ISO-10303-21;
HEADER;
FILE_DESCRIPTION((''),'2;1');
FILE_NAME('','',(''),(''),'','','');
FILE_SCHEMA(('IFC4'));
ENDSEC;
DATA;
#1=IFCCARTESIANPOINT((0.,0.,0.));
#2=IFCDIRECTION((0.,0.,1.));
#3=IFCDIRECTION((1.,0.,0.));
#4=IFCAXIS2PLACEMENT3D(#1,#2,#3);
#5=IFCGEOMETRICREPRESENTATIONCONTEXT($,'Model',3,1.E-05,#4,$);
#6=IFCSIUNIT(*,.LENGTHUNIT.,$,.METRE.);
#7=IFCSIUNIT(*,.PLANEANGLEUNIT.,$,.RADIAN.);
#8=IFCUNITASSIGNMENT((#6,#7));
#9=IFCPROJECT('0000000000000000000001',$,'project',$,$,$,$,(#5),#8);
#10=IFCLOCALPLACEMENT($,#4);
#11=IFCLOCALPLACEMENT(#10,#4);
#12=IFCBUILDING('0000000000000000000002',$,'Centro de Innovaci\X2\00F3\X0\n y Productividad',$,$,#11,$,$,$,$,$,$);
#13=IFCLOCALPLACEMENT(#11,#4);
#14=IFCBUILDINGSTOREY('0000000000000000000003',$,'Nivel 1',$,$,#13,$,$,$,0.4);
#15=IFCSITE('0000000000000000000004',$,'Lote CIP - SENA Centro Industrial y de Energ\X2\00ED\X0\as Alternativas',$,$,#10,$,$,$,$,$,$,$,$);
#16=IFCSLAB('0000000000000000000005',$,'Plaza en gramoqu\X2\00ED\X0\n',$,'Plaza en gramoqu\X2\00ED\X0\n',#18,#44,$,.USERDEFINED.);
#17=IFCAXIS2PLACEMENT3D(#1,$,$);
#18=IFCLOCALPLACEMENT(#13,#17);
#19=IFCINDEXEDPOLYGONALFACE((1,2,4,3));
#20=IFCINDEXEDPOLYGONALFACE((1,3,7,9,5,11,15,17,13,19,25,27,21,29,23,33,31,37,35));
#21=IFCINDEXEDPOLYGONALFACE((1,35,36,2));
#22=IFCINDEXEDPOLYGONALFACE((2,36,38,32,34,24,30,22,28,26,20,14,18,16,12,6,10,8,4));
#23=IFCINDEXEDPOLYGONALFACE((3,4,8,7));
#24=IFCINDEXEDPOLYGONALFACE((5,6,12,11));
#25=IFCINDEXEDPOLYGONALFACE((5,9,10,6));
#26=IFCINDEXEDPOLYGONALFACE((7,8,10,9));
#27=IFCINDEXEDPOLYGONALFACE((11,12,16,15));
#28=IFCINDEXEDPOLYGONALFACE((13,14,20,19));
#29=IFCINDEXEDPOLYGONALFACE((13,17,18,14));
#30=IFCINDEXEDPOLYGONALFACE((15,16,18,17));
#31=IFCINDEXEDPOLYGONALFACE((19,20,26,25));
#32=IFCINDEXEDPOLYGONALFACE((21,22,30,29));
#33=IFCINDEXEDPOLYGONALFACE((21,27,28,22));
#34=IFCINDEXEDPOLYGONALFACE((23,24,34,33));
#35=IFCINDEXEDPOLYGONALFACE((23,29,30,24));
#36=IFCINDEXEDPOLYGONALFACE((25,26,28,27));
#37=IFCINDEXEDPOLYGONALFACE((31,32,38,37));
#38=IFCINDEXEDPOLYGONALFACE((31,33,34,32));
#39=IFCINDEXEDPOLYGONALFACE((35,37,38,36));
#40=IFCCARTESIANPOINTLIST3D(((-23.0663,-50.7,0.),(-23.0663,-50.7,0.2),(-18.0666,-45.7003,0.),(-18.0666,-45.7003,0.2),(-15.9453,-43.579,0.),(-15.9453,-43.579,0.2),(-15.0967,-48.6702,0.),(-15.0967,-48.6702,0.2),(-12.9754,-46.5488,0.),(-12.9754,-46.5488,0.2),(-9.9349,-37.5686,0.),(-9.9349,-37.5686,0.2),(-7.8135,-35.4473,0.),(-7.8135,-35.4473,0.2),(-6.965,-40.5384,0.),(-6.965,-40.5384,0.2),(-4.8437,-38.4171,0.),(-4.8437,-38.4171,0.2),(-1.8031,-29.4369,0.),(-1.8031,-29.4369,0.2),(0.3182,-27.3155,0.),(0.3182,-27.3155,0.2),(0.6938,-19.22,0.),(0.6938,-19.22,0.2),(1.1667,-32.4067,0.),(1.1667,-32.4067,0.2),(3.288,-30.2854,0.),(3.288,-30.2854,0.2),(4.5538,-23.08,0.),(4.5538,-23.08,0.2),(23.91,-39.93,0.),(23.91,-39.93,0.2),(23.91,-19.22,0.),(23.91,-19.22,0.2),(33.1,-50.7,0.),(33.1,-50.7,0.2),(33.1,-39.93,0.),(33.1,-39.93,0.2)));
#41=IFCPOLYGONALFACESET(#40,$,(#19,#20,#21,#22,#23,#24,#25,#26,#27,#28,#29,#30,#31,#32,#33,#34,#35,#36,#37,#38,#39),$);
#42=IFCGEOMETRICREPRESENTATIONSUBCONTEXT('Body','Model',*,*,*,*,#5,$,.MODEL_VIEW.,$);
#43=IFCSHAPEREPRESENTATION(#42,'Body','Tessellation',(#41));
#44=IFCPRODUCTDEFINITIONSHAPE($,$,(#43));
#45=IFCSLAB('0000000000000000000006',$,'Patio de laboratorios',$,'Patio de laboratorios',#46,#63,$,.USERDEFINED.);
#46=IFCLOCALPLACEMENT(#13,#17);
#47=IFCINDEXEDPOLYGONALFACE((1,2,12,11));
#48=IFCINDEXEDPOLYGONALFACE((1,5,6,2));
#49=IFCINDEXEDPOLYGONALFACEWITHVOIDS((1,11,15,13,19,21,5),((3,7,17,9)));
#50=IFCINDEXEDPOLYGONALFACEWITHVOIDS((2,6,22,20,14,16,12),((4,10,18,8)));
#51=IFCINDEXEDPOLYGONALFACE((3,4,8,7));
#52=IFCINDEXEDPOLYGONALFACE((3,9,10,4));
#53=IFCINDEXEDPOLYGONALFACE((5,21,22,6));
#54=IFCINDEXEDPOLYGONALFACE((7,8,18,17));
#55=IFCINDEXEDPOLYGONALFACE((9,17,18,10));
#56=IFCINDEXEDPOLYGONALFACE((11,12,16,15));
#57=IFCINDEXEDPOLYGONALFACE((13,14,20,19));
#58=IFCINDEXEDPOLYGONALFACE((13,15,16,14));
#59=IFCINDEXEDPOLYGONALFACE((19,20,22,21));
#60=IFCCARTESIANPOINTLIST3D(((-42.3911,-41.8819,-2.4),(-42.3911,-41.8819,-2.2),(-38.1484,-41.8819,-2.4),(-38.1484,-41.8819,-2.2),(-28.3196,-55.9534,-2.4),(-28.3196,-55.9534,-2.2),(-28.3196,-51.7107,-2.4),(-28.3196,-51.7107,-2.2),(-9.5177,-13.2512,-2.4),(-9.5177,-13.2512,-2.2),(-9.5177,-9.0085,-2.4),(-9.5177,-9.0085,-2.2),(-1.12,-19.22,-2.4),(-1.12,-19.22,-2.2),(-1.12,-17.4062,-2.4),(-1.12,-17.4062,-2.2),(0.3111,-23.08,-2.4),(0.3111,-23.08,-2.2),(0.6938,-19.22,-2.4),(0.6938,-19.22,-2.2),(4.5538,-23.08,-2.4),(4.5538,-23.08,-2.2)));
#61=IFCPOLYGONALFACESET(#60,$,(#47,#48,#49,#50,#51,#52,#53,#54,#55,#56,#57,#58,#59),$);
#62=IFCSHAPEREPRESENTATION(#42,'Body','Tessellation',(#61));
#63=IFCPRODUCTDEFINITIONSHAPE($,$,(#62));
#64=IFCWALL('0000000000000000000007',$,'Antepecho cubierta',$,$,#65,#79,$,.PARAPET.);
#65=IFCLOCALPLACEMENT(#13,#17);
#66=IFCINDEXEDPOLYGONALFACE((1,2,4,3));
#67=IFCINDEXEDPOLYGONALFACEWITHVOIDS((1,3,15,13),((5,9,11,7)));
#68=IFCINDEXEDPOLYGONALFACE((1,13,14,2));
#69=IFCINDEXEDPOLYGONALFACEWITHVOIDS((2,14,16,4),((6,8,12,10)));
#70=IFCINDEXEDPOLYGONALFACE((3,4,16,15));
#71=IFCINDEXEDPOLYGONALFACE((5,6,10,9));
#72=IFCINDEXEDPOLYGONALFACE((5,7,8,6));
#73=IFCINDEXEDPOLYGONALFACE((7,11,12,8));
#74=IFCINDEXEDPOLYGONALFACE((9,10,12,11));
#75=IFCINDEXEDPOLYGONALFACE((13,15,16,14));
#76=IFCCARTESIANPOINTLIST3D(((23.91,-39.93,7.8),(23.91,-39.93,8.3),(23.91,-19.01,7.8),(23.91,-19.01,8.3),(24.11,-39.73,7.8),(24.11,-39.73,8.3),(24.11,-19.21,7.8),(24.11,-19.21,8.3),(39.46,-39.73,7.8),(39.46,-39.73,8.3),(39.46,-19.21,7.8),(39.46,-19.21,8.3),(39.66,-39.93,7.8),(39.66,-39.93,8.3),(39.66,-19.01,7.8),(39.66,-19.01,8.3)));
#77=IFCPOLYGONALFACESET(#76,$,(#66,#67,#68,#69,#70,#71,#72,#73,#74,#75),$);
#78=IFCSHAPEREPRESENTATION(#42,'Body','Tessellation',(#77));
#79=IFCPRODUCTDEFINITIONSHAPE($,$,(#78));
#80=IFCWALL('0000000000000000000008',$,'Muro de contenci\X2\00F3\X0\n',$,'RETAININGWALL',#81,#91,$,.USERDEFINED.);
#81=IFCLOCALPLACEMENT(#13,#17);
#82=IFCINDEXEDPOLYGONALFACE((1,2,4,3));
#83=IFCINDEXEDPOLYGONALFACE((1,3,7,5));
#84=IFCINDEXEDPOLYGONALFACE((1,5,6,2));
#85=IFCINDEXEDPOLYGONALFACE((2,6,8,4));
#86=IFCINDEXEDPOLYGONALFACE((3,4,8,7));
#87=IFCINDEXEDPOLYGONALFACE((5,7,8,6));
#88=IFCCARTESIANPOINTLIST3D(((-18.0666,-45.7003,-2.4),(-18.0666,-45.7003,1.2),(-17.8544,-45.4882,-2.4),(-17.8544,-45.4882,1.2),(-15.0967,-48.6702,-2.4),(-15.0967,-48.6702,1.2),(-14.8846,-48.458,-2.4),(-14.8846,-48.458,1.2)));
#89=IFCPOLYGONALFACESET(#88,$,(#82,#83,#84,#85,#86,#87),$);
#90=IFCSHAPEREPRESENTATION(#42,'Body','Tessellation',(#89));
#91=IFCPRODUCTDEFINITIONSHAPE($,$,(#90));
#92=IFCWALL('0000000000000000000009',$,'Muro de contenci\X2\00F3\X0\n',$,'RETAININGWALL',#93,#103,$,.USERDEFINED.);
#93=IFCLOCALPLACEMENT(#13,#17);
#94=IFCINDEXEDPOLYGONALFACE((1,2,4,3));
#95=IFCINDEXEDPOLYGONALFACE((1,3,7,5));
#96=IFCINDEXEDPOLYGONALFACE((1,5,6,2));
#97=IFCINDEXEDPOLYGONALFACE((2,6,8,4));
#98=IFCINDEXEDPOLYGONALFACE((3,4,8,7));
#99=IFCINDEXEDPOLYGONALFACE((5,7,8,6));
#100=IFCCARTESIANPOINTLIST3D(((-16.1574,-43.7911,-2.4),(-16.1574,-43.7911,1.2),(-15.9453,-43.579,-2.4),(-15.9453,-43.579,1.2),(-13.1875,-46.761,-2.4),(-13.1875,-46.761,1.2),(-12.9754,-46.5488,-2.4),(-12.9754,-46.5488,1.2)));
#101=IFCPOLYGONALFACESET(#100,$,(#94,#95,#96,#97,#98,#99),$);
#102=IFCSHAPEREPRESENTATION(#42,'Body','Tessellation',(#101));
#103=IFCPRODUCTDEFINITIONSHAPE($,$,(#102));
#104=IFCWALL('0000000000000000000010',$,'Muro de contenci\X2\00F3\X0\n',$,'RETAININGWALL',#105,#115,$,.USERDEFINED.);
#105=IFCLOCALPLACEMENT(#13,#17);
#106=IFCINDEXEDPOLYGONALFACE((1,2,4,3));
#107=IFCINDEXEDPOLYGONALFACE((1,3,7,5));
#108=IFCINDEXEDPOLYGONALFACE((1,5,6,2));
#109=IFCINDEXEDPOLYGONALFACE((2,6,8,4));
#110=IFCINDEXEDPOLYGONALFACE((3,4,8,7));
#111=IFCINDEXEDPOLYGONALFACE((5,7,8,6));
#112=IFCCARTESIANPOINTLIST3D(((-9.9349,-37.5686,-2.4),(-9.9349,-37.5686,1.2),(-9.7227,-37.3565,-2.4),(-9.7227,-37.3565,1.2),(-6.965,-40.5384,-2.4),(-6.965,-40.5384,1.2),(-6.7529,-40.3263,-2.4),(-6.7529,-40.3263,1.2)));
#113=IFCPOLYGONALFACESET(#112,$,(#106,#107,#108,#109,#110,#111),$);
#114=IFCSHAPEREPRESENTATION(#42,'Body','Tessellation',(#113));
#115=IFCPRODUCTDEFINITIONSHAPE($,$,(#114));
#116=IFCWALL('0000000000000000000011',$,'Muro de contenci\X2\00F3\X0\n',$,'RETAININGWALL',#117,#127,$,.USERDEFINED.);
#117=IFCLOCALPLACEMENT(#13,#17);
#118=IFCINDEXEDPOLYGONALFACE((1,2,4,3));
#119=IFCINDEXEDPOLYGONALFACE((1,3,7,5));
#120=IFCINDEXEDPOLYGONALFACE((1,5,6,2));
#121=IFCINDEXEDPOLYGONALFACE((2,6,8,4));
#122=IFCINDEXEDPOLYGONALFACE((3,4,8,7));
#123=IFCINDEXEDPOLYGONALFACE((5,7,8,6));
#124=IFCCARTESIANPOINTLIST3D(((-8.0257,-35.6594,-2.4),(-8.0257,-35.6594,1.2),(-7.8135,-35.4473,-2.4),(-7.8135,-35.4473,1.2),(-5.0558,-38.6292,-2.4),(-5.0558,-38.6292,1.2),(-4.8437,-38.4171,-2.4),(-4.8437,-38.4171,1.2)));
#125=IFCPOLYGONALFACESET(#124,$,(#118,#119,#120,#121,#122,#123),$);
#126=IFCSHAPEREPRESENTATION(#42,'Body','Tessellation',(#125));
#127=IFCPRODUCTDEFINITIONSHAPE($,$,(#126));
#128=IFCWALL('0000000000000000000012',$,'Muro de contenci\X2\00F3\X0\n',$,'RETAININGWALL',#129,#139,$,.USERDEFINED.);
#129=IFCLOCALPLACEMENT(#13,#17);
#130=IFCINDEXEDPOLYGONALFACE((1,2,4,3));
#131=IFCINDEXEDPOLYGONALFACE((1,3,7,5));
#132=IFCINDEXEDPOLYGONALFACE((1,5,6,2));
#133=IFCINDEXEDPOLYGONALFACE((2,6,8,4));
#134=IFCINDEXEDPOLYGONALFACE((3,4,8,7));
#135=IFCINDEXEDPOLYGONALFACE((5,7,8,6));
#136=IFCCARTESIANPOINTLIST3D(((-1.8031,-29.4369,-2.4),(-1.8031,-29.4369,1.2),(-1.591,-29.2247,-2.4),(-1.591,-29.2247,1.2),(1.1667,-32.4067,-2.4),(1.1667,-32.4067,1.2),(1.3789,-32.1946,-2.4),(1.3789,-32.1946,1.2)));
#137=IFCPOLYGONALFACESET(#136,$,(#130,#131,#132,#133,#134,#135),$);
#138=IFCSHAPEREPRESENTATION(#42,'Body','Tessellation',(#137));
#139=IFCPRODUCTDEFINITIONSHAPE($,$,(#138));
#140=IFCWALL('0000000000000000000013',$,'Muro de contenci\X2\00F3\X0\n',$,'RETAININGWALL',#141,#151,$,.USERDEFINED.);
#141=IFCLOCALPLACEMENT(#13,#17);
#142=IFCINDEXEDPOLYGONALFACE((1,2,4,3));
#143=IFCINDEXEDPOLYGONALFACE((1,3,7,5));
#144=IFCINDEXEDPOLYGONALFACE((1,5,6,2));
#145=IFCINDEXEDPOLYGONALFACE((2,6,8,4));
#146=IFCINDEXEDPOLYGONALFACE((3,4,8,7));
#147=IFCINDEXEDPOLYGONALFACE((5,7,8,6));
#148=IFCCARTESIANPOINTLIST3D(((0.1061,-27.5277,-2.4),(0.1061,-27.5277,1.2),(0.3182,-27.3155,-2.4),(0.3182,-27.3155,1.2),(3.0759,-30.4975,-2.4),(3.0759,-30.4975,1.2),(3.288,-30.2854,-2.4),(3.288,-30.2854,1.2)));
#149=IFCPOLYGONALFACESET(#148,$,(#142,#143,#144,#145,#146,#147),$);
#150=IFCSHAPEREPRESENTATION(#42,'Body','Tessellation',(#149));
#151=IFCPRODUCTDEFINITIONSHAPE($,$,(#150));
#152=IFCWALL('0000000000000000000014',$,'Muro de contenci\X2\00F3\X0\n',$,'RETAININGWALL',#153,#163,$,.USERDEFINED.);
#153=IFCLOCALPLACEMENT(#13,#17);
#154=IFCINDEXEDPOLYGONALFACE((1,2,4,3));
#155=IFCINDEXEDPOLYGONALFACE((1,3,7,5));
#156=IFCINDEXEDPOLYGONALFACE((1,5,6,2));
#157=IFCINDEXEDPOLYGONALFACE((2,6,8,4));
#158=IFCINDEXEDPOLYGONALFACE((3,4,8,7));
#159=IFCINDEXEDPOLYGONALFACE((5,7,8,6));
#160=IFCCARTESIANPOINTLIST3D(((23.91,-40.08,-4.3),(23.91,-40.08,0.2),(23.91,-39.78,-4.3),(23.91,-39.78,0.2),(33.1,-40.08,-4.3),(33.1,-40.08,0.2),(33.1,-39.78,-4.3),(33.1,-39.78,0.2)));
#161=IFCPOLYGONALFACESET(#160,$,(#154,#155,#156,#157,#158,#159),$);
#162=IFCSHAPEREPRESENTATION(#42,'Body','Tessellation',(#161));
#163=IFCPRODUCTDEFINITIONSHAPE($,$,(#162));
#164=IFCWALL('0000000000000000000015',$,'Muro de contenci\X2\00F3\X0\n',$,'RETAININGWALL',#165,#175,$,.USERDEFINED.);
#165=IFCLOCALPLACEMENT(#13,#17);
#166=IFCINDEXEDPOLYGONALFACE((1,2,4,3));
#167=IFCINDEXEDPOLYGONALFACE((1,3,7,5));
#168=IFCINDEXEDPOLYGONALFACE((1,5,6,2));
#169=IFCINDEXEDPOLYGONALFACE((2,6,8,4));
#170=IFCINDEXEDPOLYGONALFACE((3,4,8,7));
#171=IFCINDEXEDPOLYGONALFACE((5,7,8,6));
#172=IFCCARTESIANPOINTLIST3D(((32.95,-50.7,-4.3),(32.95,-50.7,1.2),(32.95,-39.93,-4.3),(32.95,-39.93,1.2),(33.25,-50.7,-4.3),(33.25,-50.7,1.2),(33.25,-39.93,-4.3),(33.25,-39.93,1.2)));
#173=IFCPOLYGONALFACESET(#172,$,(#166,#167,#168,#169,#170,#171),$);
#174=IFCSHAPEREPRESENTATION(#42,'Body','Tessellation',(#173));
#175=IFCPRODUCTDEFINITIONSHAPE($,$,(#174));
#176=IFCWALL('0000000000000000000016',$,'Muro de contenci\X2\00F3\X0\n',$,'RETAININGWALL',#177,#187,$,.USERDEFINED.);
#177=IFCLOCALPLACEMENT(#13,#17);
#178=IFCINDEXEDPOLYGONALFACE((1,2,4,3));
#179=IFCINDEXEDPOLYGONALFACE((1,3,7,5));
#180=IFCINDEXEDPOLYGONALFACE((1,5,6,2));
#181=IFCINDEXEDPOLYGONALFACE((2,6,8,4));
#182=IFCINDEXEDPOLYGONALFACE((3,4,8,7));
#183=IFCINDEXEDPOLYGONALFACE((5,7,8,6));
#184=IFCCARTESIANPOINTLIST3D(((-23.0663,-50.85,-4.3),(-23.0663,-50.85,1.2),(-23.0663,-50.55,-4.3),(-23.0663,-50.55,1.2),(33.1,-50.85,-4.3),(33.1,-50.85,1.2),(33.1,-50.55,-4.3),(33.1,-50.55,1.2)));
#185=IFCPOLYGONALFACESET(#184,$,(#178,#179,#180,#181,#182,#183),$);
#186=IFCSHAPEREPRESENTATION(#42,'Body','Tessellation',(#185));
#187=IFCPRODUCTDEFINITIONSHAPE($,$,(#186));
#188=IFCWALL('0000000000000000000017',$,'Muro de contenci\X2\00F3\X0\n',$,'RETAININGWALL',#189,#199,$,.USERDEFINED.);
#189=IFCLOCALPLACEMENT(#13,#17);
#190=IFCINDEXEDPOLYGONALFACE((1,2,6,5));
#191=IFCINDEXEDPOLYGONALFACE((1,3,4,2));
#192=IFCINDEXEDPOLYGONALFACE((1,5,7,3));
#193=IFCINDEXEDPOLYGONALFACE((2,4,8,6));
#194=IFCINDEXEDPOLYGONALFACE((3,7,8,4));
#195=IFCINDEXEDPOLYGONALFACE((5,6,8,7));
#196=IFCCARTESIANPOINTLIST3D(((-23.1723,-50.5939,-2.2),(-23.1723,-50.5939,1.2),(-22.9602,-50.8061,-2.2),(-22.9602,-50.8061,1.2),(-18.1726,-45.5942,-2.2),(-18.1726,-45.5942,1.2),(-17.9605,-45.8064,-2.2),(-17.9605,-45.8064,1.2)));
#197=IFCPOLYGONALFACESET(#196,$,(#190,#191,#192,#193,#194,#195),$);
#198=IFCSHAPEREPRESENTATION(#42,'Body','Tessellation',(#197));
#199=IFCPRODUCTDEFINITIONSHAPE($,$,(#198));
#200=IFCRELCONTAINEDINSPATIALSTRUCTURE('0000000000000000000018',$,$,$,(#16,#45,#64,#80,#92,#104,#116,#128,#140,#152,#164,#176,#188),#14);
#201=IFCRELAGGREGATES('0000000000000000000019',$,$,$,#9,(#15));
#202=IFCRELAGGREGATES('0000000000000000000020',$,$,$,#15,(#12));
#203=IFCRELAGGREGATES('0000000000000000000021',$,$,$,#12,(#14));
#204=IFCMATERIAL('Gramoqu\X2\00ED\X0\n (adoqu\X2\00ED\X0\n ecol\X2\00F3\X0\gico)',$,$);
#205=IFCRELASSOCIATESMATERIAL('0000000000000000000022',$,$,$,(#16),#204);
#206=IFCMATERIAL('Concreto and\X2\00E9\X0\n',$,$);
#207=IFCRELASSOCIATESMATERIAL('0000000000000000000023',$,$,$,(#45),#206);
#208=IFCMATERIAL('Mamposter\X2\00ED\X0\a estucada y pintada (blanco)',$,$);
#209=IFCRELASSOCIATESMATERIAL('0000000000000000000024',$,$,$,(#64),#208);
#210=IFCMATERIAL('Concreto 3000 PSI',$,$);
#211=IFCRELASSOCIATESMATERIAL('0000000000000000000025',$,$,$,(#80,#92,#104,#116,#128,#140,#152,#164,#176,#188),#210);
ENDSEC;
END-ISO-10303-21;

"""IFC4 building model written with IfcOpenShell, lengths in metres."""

from ifc_helpers import new_model, si_unit, frame, origin, origin_with_axes, place, context, subcontext, project, spatial, polyline, outline, extrude, material, element, save


model = new_model("IFC4")

# Units and contexts
model_context = context("Model", 3, precision=1e-05, world=origin_with_axes())
body_context = subcontext(model_context, "Body", "Model", "MODEL_VIEW")
ifc_project = project(units=[si_unit("LENGTHUNIT", "METRE"), si_unit("PLANEANGLEUNIT", "RADIAN")], contexts=[model_context])

# Site, building, storey
site_placement = place(None, origin_with_axes())
site = spatial("IfcSite", under=ifc_project, at=site_placement, Name="Lote CIP - SENA Centro Industrial y de Energías Alternativas")
building_placement = place(site_placement, origin_with_axes())
building = spatial("IfcBuilding", under=site, at=building_placement, Name="Centro de Innovación y Productividad")
storey_placement = place(building_placement, origin_with_axes())
storey = spatial("IfcBuildingStorey", under=building, at=storey_placement, Name="Nivel 1", Elevation=0.4)

# Slabs
ifc_material_1 = material(Name="Gramoquín (adoquín ecológico)")
slab_1_placement = place(storey_placement, origin_with_axes())
element("IfcSlab", 1, at=slab_1_placement, inside=storey, material=ifc_material_1, Name="Plaza en gramoquín", ObjectType="Plaza en gramoquín", PredefinedType="USERDEFINED", context=body_context, shape_type="SweptSolid", body=[
    extrude(outline(polyline([(33.1, -39.93), (33.1, -50.7), (-23.0663, -50.7), (-18.0666, -45.7003), (-15.0967, -48.6702), (-12.9754, -46.5488), (-15.9453, -43.579), (-9.9349, -37.5686), (-6.965, -40.5384), (-4.8437, -38.4171), (-7.8135, -35.4473), (-1.8031, -29.4369), (1.1667, -32.4067), (3.288, -30.2854), (0.3182, -27.3155), (4.5538, -23.08), (0.6938, -19.22), (23.91, -19.22), (23.91, -39.93), (33.1, -39.93)])), origin(), (0.0, 0.0, 1.0), 0.2),
])
ifc_material_2 = material(Name="Concreto andén")
slab_2_placement = place(storey_placement, origin_with_axes())
element("IfcSlab", 2, at=slab_2_placement, inside=storey, material=ifc_material_2, Name="Patio de laboratorios", ObjectType="Patio de laboratorios", PredefinedType="USERDEFINED", context=body_context, shape_type="SweptSolid", body=[
    extrude(outline(polyline([(-42.3911, -41.8819), (-9.5177, -9.0085), (-1.12, -17.4062), (-1.12, -19.22), (0.6938, -19.22), (4.5538, -23.08), (-28.3196, -55.9534), (-42.3911, -41.8819)]), holes=[polyline([(-38.1484, -41.8819), (-28.3196, -51.7107), (0.3111, -23.08), (-9.5177, -13.2512), (-38.1484, -41.8819)])]), frame((0.0, 0.0, -2.4)), (0.0, 0.0, 1.0), 0.2),
])

# Walls
ifc_material_3 = material(Name="Mampostería estucada y pintada (blanco)")
wall_1_placement = place(storey_placement, origin_with_axes())
element("IfcWall", 3, at=wall_1_placement, inside=storey, material=ifc_material_3, Name="Antepecho cubierta", PredefinedType="PARAPET", context=body_context, shape_type="SweptSolid", body=[
    extrude(outline(polyline([(39.66, -19.01), (39.66, -39.93), (23.91, -39.93), (23.91, -19.01), (39.66, -19.01)]), holes=[polyline([(24.11, -39.73), (39.46, -39.73), (39.46, -19.21), (24.11, -19.21), (24.11, -39.73)])]), frame((0.0, 0.0, 7.8)), (0.0, 0.0, 1.0), 0.5),
])
ifc_material_4 = material(Name="Concreto 3000 PSI")
wall_2_placement = place(storey_placement, origin_with_axes())
element("IfcWall", 4, at=wall_2_placement, inside=storey, material=ifc_material_4, Name="Muro de contención", ObjectType="RETAININGWALL", PredefinedType="USERDEFINED", context=body_context, shape_type="SweptSolid", body=[
    extrude(outline(polyline([(-18.0666, -45.7003), (-17.8544, -45.4882), (-14.8846, -48.458), (-15.0967, -48.6702), (-18.0666, -45.7003)])), frame((0.0, 0.0, -2.4)), (0.0, 0.0, 1.0), 3.6),
])
wall_3_placement = place(storey_placement, origin_with_axes())
element("IfcWall", 5, at=wall_3_placement, inside=storey, material=ifc_material_4, Name="Muro de contención", ObjectType="RETAININGWALL", PredefinedType="USERDEFINED", context=body_context, shape_type="SweptSolid", body=[
    extrude(outline(polyline([(-16.1574, -43.7911), (-15.9453, -43.579), (-12.9754, -46.5488), (-13.1875, -46.761), (-16.1574, -43.7911)])), frame((0.0, 0.0, -2.4)), (0.0, 0.0, 1.0), 3.6),
])
wall_4_placement = place(storey_placement, origin_with_axes())
element("IfcWall", 6, at=wall_4_placement, inside=storey, material=ifc_material_4, Name="Muro de contención", ObjectType="RETAININGWALL", PredefinedType="USERDEFINED", context=body_context, shape_type="SweptSolid", body=[
    extrude(outline(polyline([(-9.9349, -37.5686), (-9.7227, -37.3565), (-6.7529, -40.3263), (-6.965, -40.5384), (-9.9349, -37.5686)])), frame((0.0, 0.0, -2.4)), (0.0, 0.0, 1.0), 3.6),
])
wall_5_placement = place(storey_placement, origin_with_axes())
element("IfcWall", 7, at=wall_5_placement, inside=storey, material=ifc_material_4, Name="Muro de contención", ObjectType="RETAININGWALL", PredefinedType="USERDEFINED", context=body_context, shape_type="SweptSolid", body=[
    extrude(outline(polyline([(-8.0257, -35.6594), (-7.8135, -35.4473), (-4.8437, -38.4171), (-5.0558, -38.6292), (-8.0257, -35.6594)])), frame((0.0, 0.0, -2.4)), (0.0, 0.0, 1.0), 3.6),
])
wall_6_placement = place(storey_placement, origin_with_axes())
element("IfcWall", 8, at=wall_6_placement, inside=storey, material=ifc_material_4, Name="Muro de contención", ObjectType="RETAININGWALL", PredefinedType="USERDEFINED", context=body_context, shape_type="SweptSolid", body=[
    extrude(outline(polyline([(-1.8031, -29.4369), (-1.591, -29.2247), (1.3789, -32.1946), (1.1667, -32.4067), (-1.8031, -29.4369)])), frame((0.0, 0.0, -2.4)), (0.0, 0.0, 1.0), 3.6),
])
wall_7_placement = place(storey_placement, origin_with_axes())
element("IfcWall", 9, at=wall_7_placement, inside=storey, material=ifc_material_4, Name="Muro de contención", ObjectType="RETAININGWALL", PredefinedType="USERDEFINED", context=body_context, shape_type="SweptSolid", body=[
    extrude(outline(polyline([(0.1061, -27.5277), (0.3182, -27.3155), (3.288, -30.2854), (3.0759, -30.4975), (0.1061, -27.5277)])), frame((0.0, 0.0, -2.4)), (0.0, 0.0, 1.0), 3.6),
])
wall_8_placement = place(storey_placement, origin_with_axes())
element("IfcWall", 10, at=wall_8_placement, inside=storey, material=ifc_material_4, Name="Muro de contención", ObjectType="RETAININGWALL", PredefinedType="USERDEFINED", context=body_context, shape_type="SweptSolid", body=[
    extrude(outline(polyline([(33.1, -39.78), (33.1, -40.08), (23.91, -40.08), (23.91, -39.78), (33.1, -39.78)])), frame((0.0, 0.0, -4.3)), (0.0, 0.0, 1.0), 4.5),
])
wall_9_placement = place(storey_placement, origin_with_axes())
element("IfcWall", 11, at=wall_9_placement, inside=storey, material=ifc_material_4, Name="Muro de contención", ObjectType="RETAININGWALL", PredefinedType="USERDEFINED", context=body_context, shape_type="SweptSolid", body=[
    extrude(outline(polyline([(33.25, -50.7), (32.95, -50.7), (32.95, -39.93), (33.25, -39.93), (33.25, -50.7)])), frame((0.0, 0.0, -4.3)), (0.0, 0.0, 1.0), 5.5),
])
wall_10_placement = place(storey_placement, origin_with_axes())
element("IfcWall", 12, at=wall_10_placement, inside=storey, material=ifc_material_4, Name="Muro de contención", ObjectType="RETAININGWALL", PredefinedType="USERDEFINED", context=body_context, shape_type="SweptSolid", body=[
    extrude(outline(polyline([(-23.0663, -50.85), (-23.0663, -50.55), (33.1, -50.55), (33.1, -50.85), (-23.0663, -50.85)])), frame((0.0, 0.0, -4.3)), (0.0, 0.0, 1.0), 5.5),
])
wall_11_placement = place(storey_placement, origin_with_axes())
element("IfcWall", 13, at=wall_11_placement, inside=storey, material=ifc_material_4, Name="Muro de contención", ObjectType="RETAININGWALL", PredefinedType="USERDEFINED", context=body_context, shape_type="SweptSolid", body=[
    extrude(outline(polyline([(-18.1726, -45.5942), (-17.9605, -45.8064), (-22.9602, -50.8061), (-23.1723, -50.5939), (-18.1726, -45.5942)])), frame((0.0, 0.0, -2.2)), (0.0, 0.0, 1.0), 3.4),
])

save(model, "model.ifc")
